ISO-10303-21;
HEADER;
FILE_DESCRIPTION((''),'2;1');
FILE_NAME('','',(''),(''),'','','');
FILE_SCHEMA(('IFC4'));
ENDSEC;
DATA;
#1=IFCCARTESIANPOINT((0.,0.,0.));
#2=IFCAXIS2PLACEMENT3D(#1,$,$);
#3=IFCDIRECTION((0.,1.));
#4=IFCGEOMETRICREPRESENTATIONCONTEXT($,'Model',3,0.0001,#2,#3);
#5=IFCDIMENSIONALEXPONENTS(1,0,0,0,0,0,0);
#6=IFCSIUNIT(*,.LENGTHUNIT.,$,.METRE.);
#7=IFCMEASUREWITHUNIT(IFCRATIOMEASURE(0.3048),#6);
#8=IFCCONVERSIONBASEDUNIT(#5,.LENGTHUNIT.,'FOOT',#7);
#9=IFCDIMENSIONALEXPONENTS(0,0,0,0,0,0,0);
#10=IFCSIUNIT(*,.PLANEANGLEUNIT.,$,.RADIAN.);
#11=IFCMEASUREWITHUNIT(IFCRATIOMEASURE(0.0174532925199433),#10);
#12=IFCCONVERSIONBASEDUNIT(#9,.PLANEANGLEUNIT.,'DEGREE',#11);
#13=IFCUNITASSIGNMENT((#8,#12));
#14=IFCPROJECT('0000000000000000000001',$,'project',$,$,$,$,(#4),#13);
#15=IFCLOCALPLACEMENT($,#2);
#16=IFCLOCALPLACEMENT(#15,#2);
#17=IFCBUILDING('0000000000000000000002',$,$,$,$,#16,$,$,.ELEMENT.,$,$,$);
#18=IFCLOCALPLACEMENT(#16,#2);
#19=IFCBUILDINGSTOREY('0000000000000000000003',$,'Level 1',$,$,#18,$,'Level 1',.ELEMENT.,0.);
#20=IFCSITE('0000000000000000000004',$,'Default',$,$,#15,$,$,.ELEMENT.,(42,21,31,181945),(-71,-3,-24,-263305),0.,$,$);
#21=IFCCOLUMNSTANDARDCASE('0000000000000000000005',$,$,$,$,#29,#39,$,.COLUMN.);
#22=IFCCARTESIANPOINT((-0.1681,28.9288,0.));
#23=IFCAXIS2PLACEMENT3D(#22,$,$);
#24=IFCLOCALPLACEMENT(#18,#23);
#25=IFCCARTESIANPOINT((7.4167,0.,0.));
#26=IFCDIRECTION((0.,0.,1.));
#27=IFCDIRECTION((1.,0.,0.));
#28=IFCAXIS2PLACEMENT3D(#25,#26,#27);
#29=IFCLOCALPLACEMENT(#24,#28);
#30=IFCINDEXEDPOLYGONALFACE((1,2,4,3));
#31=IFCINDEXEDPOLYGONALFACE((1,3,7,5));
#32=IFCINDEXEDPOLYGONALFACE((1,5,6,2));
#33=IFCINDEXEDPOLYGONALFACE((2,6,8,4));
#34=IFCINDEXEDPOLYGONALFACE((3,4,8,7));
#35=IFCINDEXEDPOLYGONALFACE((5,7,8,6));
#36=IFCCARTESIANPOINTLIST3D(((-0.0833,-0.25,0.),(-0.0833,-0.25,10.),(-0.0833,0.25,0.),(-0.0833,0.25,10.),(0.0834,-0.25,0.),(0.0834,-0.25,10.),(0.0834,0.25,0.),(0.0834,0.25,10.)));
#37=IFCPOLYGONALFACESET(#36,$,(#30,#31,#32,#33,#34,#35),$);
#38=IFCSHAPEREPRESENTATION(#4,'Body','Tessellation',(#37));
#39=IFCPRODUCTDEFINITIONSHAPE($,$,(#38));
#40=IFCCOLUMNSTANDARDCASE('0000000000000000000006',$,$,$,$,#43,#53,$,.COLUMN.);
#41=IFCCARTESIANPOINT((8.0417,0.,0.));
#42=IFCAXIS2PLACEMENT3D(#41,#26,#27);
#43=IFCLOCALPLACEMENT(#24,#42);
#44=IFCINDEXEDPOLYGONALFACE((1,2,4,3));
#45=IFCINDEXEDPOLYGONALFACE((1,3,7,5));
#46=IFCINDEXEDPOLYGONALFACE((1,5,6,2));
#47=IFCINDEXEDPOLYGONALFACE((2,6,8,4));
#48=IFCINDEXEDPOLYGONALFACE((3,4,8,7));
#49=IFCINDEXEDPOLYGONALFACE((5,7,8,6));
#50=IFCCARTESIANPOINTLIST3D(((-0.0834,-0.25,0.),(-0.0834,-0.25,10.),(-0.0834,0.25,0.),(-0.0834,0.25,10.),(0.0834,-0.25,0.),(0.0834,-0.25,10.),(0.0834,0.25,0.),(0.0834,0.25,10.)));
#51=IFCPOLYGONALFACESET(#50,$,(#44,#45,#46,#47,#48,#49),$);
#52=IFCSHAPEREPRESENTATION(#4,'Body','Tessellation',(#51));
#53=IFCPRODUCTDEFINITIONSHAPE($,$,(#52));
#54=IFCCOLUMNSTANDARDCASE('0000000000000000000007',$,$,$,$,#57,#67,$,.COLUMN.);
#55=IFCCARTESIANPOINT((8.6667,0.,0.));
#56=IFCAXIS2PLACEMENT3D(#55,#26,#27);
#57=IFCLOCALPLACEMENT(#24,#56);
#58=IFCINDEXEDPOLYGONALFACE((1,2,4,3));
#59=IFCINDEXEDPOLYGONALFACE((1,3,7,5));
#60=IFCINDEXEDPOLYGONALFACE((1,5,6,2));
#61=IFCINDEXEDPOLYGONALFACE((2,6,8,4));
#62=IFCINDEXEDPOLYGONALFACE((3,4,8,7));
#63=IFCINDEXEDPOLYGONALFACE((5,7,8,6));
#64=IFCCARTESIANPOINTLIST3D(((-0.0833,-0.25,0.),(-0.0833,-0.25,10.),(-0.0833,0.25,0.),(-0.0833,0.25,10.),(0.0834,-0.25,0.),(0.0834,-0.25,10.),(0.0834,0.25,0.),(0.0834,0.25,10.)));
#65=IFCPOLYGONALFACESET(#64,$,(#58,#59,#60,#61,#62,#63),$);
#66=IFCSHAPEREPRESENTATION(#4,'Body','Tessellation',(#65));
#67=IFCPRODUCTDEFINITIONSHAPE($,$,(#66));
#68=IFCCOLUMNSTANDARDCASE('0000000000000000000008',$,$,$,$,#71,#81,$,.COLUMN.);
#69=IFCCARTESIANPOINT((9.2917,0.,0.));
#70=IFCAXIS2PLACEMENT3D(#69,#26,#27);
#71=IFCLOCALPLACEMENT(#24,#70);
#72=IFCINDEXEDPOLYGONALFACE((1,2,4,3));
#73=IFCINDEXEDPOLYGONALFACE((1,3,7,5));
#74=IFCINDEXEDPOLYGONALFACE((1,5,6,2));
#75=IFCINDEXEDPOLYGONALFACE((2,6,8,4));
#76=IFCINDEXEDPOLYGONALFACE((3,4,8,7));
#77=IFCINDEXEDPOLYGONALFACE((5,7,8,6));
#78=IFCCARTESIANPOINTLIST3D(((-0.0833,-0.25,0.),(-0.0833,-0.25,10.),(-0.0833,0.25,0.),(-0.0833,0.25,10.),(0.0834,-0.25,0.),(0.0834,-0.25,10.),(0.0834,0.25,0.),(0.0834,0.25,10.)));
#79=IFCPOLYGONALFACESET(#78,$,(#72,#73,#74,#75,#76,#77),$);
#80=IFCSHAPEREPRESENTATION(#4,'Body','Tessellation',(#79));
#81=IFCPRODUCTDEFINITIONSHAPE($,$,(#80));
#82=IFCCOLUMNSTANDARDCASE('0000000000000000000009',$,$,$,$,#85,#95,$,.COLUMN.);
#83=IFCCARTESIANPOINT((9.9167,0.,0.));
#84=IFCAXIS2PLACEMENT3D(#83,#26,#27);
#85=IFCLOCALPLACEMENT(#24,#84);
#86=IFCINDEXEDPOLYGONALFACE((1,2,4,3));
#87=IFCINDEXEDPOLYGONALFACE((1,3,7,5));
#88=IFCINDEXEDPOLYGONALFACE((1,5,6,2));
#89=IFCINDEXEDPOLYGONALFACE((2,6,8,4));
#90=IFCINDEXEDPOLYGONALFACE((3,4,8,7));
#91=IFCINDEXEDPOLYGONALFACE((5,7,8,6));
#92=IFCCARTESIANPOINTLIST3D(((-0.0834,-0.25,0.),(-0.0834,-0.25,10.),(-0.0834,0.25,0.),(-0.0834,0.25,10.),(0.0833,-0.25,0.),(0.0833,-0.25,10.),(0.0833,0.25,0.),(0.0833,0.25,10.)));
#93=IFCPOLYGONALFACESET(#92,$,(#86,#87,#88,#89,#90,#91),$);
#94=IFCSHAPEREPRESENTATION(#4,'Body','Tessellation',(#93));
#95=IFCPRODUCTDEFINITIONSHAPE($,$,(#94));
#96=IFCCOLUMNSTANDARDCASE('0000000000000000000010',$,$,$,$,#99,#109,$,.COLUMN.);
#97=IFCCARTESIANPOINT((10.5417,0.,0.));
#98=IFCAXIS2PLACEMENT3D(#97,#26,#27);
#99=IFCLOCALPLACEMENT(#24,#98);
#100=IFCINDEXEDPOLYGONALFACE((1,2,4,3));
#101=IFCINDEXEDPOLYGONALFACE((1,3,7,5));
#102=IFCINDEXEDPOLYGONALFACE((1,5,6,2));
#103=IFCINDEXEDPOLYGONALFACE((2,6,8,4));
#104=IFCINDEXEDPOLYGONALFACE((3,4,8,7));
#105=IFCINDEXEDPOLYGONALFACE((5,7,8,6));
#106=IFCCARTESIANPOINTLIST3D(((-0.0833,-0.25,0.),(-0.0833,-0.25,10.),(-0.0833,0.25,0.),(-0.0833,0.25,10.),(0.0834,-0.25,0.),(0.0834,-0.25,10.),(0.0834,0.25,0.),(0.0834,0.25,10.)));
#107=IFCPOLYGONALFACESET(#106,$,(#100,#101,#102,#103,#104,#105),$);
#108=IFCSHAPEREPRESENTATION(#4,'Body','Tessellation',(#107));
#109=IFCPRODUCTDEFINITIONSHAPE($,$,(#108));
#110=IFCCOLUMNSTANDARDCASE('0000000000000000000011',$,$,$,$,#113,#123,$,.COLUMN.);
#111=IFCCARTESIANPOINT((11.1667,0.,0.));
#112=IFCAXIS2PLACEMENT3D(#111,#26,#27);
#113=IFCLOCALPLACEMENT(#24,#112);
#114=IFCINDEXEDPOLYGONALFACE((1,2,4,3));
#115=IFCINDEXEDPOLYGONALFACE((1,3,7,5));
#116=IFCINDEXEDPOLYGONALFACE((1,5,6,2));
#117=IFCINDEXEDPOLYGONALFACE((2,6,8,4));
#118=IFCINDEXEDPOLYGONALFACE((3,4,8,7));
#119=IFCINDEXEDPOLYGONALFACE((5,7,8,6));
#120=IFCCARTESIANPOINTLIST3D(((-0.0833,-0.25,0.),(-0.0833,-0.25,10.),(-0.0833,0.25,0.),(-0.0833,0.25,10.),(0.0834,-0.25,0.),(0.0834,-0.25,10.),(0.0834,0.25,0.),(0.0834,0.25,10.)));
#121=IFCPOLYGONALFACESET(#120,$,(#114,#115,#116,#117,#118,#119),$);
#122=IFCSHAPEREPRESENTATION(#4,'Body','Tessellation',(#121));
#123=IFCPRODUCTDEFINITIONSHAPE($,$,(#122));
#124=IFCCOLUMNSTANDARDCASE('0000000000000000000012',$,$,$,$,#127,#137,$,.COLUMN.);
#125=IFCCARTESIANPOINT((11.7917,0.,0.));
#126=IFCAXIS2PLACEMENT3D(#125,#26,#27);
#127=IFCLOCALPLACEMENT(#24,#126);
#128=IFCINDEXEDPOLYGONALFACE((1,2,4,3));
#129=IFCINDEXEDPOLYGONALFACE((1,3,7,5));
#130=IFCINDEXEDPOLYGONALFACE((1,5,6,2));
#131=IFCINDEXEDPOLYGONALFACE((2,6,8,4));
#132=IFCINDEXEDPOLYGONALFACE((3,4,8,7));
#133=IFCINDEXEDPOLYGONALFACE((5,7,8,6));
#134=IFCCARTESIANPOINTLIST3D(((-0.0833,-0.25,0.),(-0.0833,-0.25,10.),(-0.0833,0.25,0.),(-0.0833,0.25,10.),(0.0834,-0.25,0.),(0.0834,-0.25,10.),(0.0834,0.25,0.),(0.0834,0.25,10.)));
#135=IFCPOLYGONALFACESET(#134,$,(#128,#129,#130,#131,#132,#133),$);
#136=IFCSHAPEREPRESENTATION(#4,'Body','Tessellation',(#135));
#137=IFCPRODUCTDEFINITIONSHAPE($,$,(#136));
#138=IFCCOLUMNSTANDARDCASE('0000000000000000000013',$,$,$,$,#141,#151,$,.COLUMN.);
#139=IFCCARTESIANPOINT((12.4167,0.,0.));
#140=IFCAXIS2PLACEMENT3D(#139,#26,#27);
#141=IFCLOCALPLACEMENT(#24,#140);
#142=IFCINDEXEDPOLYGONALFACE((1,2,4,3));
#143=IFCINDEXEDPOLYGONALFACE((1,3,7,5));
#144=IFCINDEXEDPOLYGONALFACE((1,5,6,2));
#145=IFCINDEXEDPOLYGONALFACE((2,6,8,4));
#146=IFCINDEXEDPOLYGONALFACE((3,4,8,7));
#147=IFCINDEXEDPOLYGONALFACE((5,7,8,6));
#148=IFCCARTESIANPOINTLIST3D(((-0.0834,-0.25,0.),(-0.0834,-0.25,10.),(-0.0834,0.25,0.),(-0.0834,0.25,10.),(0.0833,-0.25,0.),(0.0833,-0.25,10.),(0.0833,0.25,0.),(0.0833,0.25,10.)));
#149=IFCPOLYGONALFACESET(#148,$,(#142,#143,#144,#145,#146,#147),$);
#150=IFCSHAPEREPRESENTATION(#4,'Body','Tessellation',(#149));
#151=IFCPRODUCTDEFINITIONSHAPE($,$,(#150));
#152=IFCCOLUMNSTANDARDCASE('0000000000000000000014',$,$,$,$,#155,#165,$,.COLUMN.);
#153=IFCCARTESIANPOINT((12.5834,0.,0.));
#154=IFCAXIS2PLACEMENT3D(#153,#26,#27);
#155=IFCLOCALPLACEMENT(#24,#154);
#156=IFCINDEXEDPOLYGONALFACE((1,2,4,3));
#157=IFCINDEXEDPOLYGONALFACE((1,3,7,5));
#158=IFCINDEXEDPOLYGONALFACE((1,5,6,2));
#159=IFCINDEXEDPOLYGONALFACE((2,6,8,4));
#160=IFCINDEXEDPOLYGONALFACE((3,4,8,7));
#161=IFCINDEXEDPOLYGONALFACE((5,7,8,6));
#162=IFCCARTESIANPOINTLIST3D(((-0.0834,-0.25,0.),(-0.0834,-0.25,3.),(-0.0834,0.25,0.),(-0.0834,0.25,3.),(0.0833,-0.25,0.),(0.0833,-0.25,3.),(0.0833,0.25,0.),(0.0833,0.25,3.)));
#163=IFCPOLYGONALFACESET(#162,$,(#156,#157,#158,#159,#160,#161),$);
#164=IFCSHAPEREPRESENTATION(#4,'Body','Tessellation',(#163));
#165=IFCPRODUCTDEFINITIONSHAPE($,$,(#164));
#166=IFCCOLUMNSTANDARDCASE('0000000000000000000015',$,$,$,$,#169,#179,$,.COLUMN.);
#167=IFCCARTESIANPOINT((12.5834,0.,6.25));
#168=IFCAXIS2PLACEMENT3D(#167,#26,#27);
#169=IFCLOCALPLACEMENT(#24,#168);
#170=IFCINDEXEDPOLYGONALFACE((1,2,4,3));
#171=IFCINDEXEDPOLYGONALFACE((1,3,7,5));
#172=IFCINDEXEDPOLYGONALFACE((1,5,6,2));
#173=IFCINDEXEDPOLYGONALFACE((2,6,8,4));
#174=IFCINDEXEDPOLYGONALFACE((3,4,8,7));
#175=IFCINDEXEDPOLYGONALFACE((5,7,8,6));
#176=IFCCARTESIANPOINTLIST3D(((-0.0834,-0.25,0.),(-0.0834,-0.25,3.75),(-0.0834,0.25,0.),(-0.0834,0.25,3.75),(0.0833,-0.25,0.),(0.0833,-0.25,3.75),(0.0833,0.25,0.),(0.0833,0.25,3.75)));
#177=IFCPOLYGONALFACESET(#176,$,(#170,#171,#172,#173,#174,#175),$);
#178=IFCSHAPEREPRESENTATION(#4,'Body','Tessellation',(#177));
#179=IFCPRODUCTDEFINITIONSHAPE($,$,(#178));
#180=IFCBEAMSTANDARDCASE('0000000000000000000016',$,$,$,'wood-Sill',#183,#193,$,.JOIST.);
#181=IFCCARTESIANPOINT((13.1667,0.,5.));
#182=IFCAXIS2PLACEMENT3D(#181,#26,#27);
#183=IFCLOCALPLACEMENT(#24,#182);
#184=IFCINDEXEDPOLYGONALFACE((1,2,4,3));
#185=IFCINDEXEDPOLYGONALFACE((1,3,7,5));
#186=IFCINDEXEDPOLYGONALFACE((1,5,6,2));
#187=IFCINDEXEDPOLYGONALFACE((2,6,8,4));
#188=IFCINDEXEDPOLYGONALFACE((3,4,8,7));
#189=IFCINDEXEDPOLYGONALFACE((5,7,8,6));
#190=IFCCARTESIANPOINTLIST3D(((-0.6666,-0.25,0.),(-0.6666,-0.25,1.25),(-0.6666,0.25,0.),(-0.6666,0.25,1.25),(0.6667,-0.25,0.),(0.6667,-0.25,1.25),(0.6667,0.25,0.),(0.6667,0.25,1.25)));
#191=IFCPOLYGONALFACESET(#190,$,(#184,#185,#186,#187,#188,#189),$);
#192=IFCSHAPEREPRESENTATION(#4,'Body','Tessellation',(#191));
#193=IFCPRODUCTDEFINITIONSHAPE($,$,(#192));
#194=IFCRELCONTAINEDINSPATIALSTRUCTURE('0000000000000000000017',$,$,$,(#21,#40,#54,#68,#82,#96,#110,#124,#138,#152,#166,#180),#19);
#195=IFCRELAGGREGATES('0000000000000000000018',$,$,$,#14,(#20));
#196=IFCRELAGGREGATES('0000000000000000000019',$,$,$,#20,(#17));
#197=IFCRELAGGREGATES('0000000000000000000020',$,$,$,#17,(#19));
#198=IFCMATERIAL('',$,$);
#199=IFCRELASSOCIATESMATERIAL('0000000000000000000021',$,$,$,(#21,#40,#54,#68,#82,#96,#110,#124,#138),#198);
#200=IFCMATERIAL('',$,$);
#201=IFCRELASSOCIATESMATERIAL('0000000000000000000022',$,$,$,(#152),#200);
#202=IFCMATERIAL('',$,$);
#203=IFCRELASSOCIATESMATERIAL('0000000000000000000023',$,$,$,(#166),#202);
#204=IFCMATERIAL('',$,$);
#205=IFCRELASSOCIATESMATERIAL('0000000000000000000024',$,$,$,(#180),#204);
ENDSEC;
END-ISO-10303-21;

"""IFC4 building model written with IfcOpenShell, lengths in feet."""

from ifc_helpers import new_model, entity, si_unit, converted_unit, direction, frame, origin, place, context, project, spatial, rectangle, extrude, material, element, save


model = new_model("IFC4")

# Units and contexts
model_context = context("Model", 3, precision=0.0001, world=origin(), true_north=direction((0.0, 1.0)))
ifc_project = project(units=[converted_unit("LENGTHUNIT", "FOOT", entity("IfcRatioMeasure", 0.3048), si_unit("LENGTHUNIT", "METRE"), dimensions=[1, 0, 0, 0, 0, 0, 0]), converted_unit("PLANEANGLEUNIT", "DEGREE", entity("IfcRatioMeasure", 0.0174532925199433), si_unit("PLANEANGLEUNIT", "RADIAN"), dimensions=[0, 0, 0, 0, 0, 0, 0])], contexts=[model_context])

# Site, building, storey
site_placement = place(None, origin())
site = spatial("IfcSite", under=ifc_project, at=site_placement, Name="Default", CompositionType="ELEMENT", RefLatitude=(42, 21, 31, 181945), RefLongitude=(-71, -3, -24, -263305), RefElevation=0.0)
building_placement = place(site_placement, origin())
building = spatial("IfcBuilding", under=site, at=building_placement, CompositionType="ELEMENT")
storey_placement = place(building_placement, origin())
storey = spatial("IfcBuildingStorey", under=building, at=storey_placement, Name="Level 1", LongName="Level 1", CompositionType="ELEMENT", Elevation=0.0)

# Columns
ifc_material_1 = material(Name="")
placement = place(storey_placement, frame((-0.1681, 28.9288, 0.0)))
for number, where, z_axis, x_axis in (
    (1, (7.4167, 0.0, 0.0), (0.0, 0.0, 1.0), (1.0, 0.0, 0.0)),
    (2, (8.0417, 0.0, 0.0), (0.0, 0.0, 1.0), (1.0, 0.0, 0.0)),
    (3, (8.6667, 0.0, 0.0), (0.0, 0.0, 1.0), (1.0, 0.0, 0.0)),
    (4, (9.2917, 0.0, 0.0), (0.0, 0.0, 1.0), (1.0, 0.0, 0.0)),
    (5, (9.9167, 0.0, 0.0), (0.0, 0.0, 1.0), (1.0, 0.0, 0.0)),
    (6, (10.5417, 0.0, 0.0), (0.0, 0.0, 1.0), (1.0, 0.0, 0.0)),
    (7, (11.1667, 0.0, 0.0), (0.0, 0.0, 1.0), (1.0, 0.0, 0.0)),
    (8, (11.7917, 0.0, 0.0), (0.0, 0.0, 1.0), (1.0, 0.0, 0.0)),
    (9, (12.4167, 0.0, 0.0), (0.0, 0.0, 1.0), (1.0, 0.0, 0.0)),
):
    element("IfcColumnStandardCase", number, at=place(placement, frame(where, z_axis=z_axis, x_axis=x_axis)), inside=storey, material=ifc_material_1, PredefinedType="COLUMN", context=model_context, shape_type="SweptSolid", body=[
        extrude(rectangle(XDim=0.1667, YDim=0.5), origin(), (0.0, 0.0, 1.0), 10.0),
    ])
ifc_material_2 = material(Name="")
for number, where, z_axis, x_axis in (
    (10, (12.5834, 0.0, 0.0), (0.0, 0.0, 1.0), (1.0, 0.0, 0.0)),
):
    element("IfcColumnStandardCase", number, at=place(placement, frame(where, z_axis=z_axis, x_axis=x_axis)), inside=storey, material=ifc_material_2, PredefinedType="COLUMN", context=model_context, shape_type="SweptSolid", body=[
        extrude(rectangle(XDim=0.1667, YDim=0.5), origin(), (0.0, 0.0, 1.0), 3.0),
    ])
ifc_material_3 = material(Name="")
for number, where, z_axis, x_axis in (
    (11, (12.5834, 0.0, 6.25), (0.0, 0.0, 1.0), (1.0, 0.0, 0.0)),
):
    element("IfcColumnStandardCase", number, at=place(placement, frame(where, z_axis=z_axis, x_axis=x_axis)), inside=storey, material=ifc_material_3, PredefinedType="COLUMN", context=model_context, shape_type="SweptSolid", body=[
        extrude(rectangle(XDim=0.1667, YDim=0.5), origin(), (0.0, 0.0, 1.0), 3.75),
    ])

# Beam
ifc_material_4 = material(Name="")
for number, where, z_axis, x_axis in (
    (12, (13.1667, 0.0, 5.0), (0.0, 0.0, 1.0), (1.0, 0.0, 0.0)),
):
    element("IfcBeamStandardCase", number, at=place(placement, frame(where, z_axis=z_axis, x_axis=x_axis)), inside=storey, material=ifc_material_4, ObjectType="wood-Sill", PredefinedType="JOIST", context=model_context, shape_type="SweptSolid", body=[
        extrude(rectangle(XDim=1.3333, YDim=0.5), origin(), (0.0, 0.0, 1.0), 1.25),
    ])

save(model, "model.ifc")
